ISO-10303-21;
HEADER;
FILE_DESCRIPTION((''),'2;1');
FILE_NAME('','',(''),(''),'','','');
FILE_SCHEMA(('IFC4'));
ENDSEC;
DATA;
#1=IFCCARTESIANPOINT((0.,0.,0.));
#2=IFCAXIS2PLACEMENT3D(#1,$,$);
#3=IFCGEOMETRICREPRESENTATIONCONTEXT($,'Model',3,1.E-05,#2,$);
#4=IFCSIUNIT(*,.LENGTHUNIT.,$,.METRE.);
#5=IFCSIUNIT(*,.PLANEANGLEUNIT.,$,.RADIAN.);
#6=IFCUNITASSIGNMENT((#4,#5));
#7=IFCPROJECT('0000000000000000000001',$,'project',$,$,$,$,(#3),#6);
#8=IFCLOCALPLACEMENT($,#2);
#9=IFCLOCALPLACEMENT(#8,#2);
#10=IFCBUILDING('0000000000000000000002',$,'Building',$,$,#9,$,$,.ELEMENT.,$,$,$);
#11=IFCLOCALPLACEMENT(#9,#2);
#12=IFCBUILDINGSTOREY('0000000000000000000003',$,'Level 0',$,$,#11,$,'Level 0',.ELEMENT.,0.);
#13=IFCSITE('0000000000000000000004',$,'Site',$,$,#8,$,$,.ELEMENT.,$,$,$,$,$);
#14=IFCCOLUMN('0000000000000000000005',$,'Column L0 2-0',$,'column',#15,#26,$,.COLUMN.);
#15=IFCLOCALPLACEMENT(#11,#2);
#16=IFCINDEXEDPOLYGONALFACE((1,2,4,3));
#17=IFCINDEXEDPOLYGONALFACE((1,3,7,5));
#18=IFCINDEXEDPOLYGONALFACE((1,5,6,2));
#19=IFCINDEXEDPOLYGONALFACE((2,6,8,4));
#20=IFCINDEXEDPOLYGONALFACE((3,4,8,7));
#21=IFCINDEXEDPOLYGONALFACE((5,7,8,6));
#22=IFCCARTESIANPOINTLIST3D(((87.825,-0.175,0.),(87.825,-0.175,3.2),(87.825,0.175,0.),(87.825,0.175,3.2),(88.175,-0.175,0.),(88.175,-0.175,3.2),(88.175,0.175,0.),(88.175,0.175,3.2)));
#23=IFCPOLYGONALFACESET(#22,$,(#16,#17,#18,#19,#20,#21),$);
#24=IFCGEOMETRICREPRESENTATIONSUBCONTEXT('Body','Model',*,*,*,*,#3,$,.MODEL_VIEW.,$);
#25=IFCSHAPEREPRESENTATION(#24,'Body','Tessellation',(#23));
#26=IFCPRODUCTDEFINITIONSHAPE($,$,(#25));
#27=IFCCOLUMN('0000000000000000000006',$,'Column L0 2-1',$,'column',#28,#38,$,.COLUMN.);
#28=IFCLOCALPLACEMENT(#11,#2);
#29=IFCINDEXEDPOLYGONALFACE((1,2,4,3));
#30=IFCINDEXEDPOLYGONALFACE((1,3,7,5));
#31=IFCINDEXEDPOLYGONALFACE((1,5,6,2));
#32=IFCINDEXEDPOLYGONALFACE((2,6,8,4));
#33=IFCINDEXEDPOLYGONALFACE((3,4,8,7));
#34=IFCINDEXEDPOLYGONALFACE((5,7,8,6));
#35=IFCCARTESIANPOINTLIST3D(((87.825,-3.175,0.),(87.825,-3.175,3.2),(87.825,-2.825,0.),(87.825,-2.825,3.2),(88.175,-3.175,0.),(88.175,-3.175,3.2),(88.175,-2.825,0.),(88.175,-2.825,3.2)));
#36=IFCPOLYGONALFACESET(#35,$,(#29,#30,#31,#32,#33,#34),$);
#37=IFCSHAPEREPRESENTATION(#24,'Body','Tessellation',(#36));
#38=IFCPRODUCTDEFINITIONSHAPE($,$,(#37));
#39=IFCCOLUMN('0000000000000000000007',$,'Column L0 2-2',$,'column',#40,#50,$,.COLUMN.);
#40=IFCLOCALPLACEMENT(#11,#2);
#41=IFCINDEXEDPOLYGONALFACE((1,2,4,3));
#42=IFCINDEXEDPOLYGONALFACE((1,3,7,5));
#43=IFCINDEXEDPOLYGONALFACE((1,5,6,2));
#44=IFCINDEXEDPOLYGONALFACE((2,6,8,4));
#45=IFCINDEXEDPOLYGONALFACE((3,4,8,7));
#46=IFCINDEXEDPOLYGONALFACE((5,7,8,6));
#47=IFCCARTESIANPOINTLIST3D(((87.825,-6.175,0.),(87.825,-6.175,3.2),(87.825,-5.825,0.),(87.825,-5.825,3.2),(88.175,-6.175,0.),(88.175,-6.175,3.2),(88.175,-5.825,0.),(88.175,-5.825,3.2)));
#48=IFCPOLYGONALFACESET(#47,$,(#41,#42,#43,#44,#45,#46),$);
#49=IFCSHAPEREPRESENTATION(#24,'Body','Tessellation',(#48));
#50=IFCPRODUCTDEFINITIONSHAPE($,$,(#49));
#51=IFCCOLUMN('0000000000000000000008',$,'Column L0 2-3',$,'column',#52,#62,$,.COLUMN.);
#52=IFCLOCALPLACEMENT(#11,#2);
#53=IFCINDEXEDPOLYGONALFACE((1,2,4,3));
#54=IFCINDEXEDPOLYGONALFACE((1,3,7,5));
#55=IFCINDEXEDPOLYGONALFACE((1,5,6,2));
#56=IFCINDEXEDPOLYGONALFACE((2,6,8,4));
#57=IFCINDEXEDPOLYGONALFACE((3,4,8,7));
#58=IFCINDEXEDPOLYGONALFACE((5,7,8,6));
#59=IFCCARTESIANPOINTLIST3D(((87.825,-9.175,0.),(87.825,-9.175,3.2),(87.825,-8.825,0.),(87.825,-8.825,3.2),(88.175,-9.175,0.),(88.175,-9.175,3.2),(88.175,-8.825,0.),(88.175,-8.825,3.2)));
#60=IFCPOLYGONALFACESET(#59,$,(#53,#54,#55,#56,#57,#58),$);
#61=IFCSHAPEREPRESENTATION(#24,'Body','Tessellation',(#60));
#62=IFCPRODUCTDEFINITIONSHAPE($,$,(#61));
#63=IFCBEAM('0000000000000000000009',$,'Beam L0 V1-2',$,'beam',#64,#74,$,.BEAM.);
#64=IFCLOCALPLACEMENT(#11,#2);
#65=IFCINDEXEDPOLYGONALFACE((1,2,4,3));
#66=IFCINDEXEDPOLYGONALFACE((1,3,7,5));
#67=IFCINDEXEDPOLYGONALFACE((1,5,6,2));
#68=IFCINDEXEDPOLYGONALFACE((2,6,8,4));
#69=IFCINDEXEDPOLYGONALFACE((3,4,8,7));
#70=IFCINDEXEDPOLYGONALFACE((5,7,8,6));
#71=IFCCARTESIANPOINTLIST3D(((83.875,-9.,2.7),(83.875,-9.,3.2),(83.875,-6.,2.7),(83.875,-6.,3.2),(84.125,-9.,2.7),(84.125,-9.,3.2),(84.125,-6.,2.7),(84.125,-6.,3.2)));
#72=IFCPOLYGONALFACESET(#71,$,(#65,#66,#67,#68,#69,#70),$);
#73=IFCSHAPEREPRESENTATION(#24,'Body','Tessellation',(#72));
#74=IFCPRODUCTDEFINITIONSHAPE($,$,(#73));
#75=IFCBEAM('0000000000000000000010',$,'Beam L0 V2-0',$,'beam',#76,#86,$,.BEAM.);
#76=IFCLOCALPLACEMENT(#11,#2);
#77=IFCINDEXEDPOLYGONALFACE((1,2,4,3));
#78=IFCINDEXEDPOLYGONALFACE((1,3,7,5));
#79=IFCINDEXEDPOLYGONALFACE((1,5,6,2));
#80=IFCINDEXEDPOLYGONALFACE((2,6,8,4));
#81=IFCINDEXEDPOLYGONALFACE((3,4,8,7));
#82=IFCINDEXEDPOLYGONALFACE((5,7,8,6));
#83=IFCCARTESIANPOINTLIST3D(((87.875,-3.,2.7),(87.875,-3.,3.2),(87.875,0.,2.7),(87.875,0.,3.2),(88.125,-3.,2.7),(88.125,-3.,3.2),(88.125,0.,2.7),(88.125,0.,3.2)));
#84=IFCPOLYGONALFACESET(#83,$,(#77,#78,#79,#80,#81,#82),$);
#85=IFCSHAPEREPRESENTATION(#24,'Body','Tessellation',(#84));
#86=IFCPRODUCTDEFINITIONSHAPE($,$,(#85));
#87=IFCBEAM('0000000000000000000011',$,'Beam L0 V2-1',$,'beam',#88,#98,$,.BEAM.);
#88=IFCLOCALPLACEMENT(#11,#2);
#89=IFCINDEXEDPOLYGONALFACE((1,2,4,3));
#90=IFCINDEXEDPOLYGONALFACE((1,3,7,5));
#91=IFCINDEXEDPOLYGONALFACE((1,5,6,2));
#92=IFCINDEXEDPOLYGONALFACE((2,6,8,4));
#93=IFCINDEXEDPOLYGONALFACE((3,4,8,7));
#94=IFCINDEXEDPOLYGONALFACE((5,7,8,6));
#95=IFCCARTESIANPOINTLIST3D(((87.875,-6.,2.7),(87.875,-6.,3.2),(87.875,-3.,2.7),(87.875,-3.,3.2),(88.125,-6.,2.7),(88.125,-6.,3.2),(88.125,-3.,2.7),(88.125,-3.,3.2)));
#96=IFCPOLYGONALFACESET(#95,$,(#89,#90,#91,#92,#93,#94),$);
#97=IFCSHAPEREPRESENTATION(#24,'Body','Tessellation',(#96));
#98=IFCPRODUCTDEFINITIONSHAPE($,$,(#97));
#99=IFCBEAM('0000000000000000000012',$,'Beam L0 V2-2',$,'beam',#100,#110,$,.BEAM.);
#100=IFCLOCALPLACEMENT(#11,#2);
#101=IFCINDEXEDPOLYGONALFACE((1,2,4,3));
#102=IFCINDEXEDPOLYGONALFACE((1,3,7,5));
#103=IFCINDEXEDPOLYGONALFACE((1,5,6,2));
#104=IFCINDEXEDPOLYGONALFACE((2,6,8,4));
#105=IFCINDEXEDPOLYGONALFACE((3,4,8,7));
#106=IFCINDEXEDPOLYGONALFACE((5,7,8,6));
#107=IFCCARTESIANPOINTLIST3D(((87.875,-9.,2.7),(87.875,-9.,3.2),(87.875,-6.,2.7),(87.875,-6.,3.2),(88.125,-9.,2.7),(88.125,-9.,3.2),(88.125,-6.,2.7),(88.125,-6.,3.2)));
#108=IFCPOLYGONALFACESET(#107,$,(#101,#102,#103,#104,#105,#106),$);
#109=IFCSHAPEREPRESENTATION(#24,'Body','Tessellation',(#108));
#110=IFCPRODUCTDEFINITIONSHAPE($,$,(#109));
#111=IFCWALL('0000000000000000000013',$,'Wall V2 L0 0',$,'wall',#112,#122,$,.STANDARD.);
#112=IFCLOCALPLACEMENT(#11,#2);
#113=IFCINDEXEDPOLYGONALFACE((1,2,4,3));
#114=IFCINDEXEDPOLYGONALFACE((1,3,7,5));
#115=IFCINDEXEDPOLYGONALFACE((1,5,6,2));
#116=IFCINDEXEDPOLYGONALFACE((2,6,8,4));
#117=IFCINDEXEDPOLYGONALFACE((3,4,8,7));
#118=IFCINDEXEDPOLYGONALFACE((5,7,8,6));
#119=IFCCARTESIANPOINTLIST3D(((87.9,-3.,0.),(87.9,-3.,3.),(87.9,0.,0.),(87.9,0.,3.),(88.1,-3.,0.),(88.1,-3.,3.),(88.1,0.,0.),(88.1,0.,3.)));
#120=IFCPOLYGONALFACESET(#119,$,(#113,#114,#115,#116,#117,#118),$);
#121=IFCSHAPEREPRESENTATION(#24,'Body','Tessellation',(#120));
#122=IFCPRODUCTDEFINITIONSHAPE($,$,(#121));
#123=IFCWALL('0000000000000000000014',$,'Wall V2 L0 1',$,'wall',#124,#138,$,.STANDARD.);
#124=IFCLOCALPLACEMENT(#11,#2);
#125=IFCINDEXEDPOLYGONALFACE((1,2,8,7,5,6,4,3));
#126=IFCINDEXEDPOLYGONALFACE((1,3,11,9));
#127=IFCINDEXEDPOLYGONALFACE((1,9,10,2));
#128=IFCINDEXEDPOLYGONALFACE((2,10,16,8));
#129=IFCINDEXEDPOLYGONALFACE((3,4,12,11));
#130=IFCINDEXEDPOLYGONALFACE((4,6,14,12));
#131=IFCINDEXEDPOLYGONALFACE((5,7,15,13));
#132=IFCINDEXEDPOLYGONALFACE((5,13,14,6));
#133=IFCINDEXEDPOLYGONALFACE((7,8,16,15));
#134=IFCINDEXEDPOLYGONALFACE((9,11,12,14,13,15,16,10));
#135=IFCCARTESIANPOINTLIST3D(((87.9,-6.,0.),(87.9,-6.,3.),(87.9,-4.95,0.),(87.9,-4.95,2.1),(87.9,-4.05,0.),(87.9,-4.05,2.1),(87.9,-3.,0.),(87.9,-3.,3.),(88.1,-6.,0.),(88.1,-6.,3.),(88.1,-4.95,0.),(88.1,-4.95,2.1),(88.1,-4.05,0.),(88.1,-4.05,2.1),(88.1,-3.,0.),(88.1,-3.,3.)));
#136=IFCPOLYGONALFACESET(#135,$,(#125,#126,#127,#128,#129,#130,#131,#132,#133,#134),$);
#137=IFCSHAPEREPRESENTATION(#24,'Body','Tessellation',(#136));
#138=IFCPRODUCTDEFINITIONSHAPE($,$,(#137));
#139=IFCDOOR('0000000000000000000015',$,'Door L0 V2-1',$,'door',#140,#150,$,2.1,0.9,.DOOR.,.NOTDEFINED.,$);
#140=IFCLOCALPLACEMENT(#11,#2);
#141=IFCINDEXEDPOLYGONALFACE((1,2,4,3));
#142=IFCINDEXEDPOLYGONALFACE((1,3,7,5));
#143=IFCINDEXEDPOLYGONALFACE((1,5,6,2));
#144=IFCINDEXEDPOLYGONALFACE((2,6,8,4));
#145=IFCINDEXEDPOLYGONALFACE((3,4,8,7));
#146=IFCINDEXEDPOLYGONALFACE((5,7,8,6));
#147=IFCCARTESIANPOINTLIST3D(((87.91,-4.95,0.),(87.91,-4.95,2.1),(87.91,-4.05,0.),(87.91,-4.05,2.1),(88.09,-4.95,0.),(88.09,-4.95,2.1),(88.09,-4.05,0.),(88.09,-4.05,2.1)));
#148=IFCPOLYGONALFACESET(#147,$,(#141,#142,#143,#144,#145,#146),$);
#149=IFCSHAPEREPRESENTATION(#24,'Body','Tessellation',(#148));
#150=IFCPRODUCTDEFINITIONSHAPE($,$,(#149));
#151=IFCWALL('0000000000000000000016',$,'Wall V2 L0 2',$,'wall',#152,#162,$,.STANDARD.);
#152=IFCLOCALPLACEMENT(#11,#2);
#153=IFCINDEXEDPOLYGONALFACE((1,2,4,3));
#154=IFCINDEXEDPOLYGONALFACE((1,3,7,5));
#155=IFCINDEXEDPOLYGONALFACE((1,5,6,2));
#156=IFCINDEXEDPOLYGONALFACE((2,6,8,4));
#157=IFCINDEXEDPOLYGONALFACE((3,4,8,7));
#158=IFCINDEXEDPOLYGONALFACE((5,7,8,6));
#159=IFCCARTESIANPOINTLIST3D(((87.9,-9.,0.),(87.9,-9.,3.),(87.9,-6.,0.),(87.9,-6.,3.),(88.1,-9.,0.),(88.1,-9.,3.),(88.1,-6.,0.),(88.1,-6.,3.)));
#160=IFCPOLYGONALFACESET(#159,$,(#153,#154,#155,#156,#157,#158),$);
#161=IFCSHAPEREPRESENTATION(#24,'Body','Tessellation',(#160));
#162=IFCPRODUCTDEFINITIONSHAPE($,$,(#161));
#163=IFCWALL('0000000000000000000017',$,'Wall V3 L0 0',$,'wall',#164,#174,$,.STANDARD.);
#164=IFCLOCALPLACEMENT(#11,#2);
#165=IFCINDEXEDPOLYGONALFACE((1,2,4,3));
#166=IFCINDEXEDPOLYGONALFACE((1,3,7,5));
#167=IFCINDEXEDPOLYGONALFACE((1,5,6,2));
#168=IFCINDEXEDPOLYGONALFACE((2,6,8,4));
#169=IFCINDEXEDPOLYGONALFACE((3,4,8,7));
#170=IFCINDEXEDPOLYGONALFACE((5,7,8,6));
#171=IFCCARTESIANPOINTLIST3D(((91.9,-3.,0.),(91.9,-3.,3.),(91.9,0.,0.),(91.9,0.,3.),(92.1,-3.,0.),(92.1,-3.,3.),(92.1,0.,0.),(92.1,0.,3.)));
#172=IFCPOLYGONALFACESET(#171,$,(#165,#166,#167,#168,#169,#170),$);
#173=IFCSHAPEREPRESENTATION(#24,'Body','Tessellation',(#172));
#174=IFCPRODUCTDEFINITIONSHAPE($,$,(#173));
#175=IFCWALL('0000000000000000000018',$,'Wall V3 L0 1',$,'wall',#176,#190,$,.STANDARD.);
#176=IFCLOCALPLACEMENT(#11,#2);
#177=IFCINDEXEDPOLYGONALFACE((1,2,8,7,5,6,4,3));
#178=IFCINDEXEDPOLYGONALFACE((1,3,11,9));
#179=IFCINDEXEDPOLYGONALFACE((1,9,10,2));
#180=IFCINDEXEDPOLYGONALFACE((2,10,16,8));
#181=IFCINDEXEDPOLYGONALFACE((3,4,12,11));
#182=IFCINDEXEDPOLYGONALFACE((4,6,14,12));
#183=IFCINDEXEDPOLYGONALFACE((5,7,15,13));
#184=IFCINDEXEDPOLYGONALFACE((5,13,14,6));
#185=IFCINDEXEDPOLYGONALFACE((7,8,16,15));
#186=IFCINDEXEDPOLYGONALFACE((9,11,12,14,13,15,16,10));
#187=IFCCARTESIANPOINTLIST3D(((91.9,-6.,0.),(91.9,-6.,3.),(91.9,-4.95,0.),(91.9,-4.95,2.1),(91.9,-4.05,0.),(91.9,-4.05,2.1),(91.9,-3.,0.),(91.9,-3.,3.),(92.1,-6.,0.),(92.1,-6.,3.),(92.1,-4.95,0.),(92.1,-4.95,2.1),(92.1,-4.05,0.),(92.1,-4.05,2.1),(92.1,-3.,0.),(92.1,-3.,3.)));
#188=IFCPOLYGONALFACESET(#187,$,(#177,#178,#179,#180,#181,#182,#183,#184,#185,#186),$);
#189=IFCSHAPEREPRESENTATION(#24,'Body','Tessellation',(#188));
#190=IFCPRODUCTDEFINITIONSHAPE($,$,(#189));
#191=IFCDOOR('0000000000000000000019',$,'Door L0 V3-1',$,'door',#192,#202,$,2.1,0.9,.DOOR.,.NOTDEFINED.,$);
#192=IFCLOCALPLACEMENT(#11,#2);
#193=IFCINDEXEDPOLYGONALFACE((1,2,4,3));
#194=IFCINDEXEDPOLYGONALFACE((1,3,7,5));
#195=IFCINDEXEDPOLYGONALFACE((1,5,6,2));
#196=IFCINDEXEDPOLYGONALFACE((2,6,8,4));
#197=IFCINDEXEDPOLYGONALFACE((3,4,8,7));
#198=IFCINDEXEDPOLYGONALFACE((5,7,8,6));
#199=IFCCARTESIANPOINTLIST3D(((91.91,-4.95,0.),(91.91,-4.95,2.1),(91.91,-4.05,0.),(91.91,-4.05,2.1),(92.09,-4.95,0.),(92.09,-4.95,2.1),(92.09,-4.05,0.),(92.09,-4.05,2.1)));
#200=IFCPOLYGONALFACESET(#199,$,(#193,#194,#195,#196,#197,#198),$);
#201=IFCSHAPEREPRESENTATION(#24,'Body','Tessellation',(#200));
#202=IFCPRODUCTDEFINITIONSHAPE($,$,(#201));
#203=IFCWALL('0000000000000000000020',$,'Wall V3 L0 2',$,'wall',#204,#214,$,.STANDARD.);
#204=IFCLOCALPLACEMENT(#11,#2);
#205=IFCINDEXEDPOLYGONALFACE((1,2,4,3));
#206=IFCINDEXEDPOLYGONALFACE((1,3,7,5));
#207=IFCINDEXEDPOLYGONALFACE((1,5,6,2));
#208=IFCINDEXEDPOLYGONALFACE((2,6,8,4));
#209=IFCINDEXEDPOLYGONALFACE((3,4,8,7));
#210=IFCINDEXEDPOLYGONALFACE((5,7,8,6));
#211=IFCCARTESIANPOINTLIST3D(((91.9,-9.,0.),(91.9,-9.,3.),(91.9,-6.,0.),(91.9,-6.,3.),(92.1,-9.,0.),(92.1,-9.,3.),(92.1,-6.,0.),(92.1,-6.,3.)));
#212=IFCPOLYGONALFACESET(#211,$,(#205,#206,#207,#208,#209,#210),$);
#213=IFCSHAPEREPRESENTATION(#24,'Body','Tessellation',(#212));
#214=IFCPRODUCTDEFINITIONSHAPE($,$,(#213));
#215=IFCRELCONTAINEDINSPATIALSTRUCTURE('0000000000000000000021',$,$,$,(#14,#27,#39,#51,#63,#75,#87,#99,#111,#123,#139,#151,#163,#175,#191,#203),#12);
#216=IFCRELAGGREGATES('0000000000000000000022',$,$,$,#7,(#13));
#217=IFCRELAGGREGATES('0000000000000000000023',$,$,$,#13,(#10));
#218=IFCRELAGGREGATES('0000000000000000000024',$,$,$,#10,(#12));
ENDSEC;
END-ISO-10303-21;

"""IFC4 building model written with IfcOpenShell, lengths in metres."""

from ifc_helpers import new_model, si_unit, frame, frame_2d, origin, origin_2d, place, context, subcontext, project, spatial, rectangle, extrude, element, fill, save


model = new_model("IFC4")

# Units and contexts
model_context = context("Model", 3, precision=1e-05, world=origin())
body_context = subcontext(model_context, "Body", "Model", "MODEL_VIEW")
ifc_project = project(units=[si_unit("LENGTHUNIT", "METRE"), si_unit("PLANEANGLEUNIT", "RADIAN")], contexts=[model_context])

# Site, building, storey
site_placement = place(None, origin())
site = spatial("IfcSite", under=ifc_project, at=site_placement, Name="Site", CompositionType="ELEMENT")
building_placement = place(site_placement, origin())
building = spatial("IfcBuilding", under=site, at=building_placement, Name="Building", CompositionType="ELEMENT")
storey_placement = place(building_placement, origin())
storey = spatial("IfcBuildingStorey", under=building, at=storey_placement, Name="Level 0", LongName="Level 0", CompositionType="ELEMENT", Elevation=0.0)

# Columns
for number, where, name in (
    (1, (88.0, 0.0, 0.0), "Column L0 2-0"),
    (2, (88.0, -3.0, 0.0), "Column L0 2-1"),
    (3, (88.0, -6.0, 0.0), "Column L0 2-2"),
    (4, (88.0, -9.0, 0.0), "Column L0 2-3"),
):
    element("IfcColumn", number, at=place(storey_placement, frame(where)), inside=storey, Name=name, ObjectType="column", PredefinedType="COLUMN", context=body_context, shape_type="SweptSolid", body=[
        extrude(rectangle(XDim=0.35, YDim=0.35, at=origin_2d()), origin(), (0.0, 0.0, 1.0), 3.2),
    ])

# Beams
for number, where, z_axis, x_axis, name in (
    (5, (84.0, -6.0, 2.95), (0.0, -1.0, 0.0), (0.0, 0.0, 1.0), "Beam L0 V1-2"),
    (6, (88.0, 0.0, 2.95), (0.0, -1.0, 0.0), (0.0, 0.0, 1.0), "Beam L0 V2-0"),
    (7, (88.0, -3.0, 2.95), (0.0, -1.0, 0.0), (0.0, 0.0, 1.0), "Beam L0 V2-1"),
    (8, (88.0, -6.0, 2.95), (0.0, -1.0, 0.0), (0.0, 0.0, 1.0), "Beam L0 V2-2"),
):
    element("IfcBeam", number, at=place(storey_placement, frame(where, z_axis=z_axis, x_axis=x_axis)), inside=storey, Name=name, ObjectType="beam", PredefinedType="BEAM", context=body_context, shape_type="SweptSolid", body=[
        extrude(rectangle(XDim=0.5, YDim=0.25, at=origin_2d()), origin(), (0.0, 0.0, 1.0), 3.0),
    ])

# Wall
wall_1_placement = place(storey_placement, frame((88.0, 0.0, 0.0), z_axis=(0.0, 0.0, 1.0), x_axis=(0.0, -1.0, 0.0)))
element("IfcWall", 9, at=wall_1_placement, inside=storey, Name="Wall V2 L0 0", ObjectType="wall", PredefinedType="STANDARD", context=body_context, shape_type="SweptSolid", body=[
    extrude(rectangle(XDim=3.0, YDim=0.2, at=frame_2d((1.5, 0.0))), origin(), (0.0, 0.0, 1.0), 3.0),
])

# Wall, opening, door
wall_2_placement = place(storey_placement, frame((88.0, -3.0, 0.0), z_axis=(0.0, 0.0, 1.0), x_axis=(0.0, -1.0, 0.0)))
wall_2 = element("IfcWall", 10, at=wall_2_placement, inside=storey, Name="Wall V2 L0 1", ObjectType="wall", PredefinedType="STANDARD", context=body_context, shape_type="SweptSolid", body=[
    extrude(rectangle(XDim=3.0, YDim=0.2, at=frame_2d((1.5, 0.0))), origin(), (0.0, 0.0, 1.0), 3.0),
])
opening_1_placement = place(storey_placement, frame((88.0, -4.5, 0.0), z_axis=(0.0, 0.0, 1.0), x_axis=(0.0, -1.0, 0.0)))
opening_1 = element("IfcOpeningElement", 11, at=opening_1_placement, cuts=wall_2, ObjectType="Opening", PredefinedType="OPENING", context=body_context, shape_type="SweptSolid", body=[
    extrude(rectangle(XDim=0.9, YDim=0.22, at=origin_2d()), origin(), (0.0, 0.0, 1.0), 2.1),
])
door_1_placement = place(storey_placement, frame((88.0, -4.5, 0.0), z_axis=(0.0, 0.0, 1.0), x_axis=(0.0, -1.0, 0.0)))
door_1 = element("IfcDoor", 12, at=door_1_placement, inside=storey, Name="Door L0 V2-1", ObjectType="door", OperationType="NOTDEFINED", OverallHeight=2.1, OverallWidth=0.9, PredefinedType="DOOR", context=body_context, shape_type="SweptSolid", body=[
    extrude(rectangle(XDim=0.9, YDim=0.18, at=origin_2d()), origin(), (0.0, 0.0, 1.0), 2.1),
])
fill(opening_1, door_1)

# Walls
for number, where, z_axis, x_axis, name in (
    (13, (88.0, -6.0, 0.0), (0.0, 0.0, 1.0), (0.0, -1.0, 0.0), "Wall V2 L0 2"),
    (14, (92.0, 0.0, 0.0), (0.0, 0.0, 1.0), (0.0, -1.0, 0.0), "Wall V3 L0 0"),
):
    element("IfcWall", number, at=place(storey_placement, frame(where, z_axis=z_axis, x_axis=x_axis)), inside=storey, Name=name, ObjectType="wall", PredefinedType="STANDARD", context=body_context, shape_type="SweptSolid", body=[
        extrude(rectangle(XDim=3.0, YDim=0.2, at=frame_2d((1.5, 0.0))), origin(), (0.0, 0.0, 1.0), 3.0),
    ])

# Wall, opening, door
wall_3_placement = place(storey_placement, frame((92.0, -3.0, 0.0), z_axis=(0.0, 0.0, 1.0), x_axis=(0.0, -1.0, 0.0)))
wall_3 = element("IfcWall", 15, at=wall_3_placement, inside=storey, Name="Wall V3 L0 1", ObjectType="wall", PredefinedType="STANDARD", context=body_context, shape_type="SweptSolid", body=[
    extrude(rectangle(XDim=3.0, YDim=0.2, at=frame_2d((1.5, 0.0))), origin(), (0.0, 0.0, 1.0), 3.0),
])
opening_2_placement = place(storey_placement, frame((92.0, -4.5, 0.0), z_axis=(0.0, 0.0, 1.0), x_axis=(0.0, -1.0, 0.0)))
opening_2 = element("IfcOpeningElement", 16, at=opening_2_placement, cuts=wall_3, ObjectType="Opening", PredefinedType="OPENING", context=body_context, shape_type="SweptSolid", body=[
    extrude(rectangle(XDim=0.9, YDim=0.22, at=origin_2d()), origin(), (0.0, 0.0, 1.0), 2.1),
])
door_2_placement = place(storey_placement, frame((92.0, -4.5, 0.0), z_axis=(0.0, 0.0, 1.0), x_axis=(0.0, -1.0, 0.0)))
door_2 = element("IfcDoor", 17, at=door_2_placement, inside=storey, Name="Door L0 V3-1", ObjectType="door", OperationType="NOTDEFINED", OverallHeight=2.1, OverallWidth=0.9, PredefinedType="DOOR", context=body_context, shape_type="SweptSolid", body=[
    extrude(rectangle(XDim=0.9, YDim=0.18, at=origin_2d()), origin(), (0.0, 0.0, 1.0), 2.1),
])
fill(opening_2, door_2)

# Wall
wall_4_placement = place(storey_placement, frame((92.0, -6.0, 0.0), z_axis=(0.0, 0.0, 1.0), x_axis=(0.0, -1.0, 0.0)))
element("IfcWall", 18, at=wall_4_placement, inside=storey, Name="Wall V3 L0 2", ObjectType="wall", PredefinedType="STANDARD", context=body_context, shape_type="SweptSolid", body=[
    extrude(rectangle(XDim=3.0, YDim=0.2, at=frame_2d((1.5, 0.0))), origin(), (0.0, 0.0, 1.0), 3.0),
])

save(model, "model.ifc")
